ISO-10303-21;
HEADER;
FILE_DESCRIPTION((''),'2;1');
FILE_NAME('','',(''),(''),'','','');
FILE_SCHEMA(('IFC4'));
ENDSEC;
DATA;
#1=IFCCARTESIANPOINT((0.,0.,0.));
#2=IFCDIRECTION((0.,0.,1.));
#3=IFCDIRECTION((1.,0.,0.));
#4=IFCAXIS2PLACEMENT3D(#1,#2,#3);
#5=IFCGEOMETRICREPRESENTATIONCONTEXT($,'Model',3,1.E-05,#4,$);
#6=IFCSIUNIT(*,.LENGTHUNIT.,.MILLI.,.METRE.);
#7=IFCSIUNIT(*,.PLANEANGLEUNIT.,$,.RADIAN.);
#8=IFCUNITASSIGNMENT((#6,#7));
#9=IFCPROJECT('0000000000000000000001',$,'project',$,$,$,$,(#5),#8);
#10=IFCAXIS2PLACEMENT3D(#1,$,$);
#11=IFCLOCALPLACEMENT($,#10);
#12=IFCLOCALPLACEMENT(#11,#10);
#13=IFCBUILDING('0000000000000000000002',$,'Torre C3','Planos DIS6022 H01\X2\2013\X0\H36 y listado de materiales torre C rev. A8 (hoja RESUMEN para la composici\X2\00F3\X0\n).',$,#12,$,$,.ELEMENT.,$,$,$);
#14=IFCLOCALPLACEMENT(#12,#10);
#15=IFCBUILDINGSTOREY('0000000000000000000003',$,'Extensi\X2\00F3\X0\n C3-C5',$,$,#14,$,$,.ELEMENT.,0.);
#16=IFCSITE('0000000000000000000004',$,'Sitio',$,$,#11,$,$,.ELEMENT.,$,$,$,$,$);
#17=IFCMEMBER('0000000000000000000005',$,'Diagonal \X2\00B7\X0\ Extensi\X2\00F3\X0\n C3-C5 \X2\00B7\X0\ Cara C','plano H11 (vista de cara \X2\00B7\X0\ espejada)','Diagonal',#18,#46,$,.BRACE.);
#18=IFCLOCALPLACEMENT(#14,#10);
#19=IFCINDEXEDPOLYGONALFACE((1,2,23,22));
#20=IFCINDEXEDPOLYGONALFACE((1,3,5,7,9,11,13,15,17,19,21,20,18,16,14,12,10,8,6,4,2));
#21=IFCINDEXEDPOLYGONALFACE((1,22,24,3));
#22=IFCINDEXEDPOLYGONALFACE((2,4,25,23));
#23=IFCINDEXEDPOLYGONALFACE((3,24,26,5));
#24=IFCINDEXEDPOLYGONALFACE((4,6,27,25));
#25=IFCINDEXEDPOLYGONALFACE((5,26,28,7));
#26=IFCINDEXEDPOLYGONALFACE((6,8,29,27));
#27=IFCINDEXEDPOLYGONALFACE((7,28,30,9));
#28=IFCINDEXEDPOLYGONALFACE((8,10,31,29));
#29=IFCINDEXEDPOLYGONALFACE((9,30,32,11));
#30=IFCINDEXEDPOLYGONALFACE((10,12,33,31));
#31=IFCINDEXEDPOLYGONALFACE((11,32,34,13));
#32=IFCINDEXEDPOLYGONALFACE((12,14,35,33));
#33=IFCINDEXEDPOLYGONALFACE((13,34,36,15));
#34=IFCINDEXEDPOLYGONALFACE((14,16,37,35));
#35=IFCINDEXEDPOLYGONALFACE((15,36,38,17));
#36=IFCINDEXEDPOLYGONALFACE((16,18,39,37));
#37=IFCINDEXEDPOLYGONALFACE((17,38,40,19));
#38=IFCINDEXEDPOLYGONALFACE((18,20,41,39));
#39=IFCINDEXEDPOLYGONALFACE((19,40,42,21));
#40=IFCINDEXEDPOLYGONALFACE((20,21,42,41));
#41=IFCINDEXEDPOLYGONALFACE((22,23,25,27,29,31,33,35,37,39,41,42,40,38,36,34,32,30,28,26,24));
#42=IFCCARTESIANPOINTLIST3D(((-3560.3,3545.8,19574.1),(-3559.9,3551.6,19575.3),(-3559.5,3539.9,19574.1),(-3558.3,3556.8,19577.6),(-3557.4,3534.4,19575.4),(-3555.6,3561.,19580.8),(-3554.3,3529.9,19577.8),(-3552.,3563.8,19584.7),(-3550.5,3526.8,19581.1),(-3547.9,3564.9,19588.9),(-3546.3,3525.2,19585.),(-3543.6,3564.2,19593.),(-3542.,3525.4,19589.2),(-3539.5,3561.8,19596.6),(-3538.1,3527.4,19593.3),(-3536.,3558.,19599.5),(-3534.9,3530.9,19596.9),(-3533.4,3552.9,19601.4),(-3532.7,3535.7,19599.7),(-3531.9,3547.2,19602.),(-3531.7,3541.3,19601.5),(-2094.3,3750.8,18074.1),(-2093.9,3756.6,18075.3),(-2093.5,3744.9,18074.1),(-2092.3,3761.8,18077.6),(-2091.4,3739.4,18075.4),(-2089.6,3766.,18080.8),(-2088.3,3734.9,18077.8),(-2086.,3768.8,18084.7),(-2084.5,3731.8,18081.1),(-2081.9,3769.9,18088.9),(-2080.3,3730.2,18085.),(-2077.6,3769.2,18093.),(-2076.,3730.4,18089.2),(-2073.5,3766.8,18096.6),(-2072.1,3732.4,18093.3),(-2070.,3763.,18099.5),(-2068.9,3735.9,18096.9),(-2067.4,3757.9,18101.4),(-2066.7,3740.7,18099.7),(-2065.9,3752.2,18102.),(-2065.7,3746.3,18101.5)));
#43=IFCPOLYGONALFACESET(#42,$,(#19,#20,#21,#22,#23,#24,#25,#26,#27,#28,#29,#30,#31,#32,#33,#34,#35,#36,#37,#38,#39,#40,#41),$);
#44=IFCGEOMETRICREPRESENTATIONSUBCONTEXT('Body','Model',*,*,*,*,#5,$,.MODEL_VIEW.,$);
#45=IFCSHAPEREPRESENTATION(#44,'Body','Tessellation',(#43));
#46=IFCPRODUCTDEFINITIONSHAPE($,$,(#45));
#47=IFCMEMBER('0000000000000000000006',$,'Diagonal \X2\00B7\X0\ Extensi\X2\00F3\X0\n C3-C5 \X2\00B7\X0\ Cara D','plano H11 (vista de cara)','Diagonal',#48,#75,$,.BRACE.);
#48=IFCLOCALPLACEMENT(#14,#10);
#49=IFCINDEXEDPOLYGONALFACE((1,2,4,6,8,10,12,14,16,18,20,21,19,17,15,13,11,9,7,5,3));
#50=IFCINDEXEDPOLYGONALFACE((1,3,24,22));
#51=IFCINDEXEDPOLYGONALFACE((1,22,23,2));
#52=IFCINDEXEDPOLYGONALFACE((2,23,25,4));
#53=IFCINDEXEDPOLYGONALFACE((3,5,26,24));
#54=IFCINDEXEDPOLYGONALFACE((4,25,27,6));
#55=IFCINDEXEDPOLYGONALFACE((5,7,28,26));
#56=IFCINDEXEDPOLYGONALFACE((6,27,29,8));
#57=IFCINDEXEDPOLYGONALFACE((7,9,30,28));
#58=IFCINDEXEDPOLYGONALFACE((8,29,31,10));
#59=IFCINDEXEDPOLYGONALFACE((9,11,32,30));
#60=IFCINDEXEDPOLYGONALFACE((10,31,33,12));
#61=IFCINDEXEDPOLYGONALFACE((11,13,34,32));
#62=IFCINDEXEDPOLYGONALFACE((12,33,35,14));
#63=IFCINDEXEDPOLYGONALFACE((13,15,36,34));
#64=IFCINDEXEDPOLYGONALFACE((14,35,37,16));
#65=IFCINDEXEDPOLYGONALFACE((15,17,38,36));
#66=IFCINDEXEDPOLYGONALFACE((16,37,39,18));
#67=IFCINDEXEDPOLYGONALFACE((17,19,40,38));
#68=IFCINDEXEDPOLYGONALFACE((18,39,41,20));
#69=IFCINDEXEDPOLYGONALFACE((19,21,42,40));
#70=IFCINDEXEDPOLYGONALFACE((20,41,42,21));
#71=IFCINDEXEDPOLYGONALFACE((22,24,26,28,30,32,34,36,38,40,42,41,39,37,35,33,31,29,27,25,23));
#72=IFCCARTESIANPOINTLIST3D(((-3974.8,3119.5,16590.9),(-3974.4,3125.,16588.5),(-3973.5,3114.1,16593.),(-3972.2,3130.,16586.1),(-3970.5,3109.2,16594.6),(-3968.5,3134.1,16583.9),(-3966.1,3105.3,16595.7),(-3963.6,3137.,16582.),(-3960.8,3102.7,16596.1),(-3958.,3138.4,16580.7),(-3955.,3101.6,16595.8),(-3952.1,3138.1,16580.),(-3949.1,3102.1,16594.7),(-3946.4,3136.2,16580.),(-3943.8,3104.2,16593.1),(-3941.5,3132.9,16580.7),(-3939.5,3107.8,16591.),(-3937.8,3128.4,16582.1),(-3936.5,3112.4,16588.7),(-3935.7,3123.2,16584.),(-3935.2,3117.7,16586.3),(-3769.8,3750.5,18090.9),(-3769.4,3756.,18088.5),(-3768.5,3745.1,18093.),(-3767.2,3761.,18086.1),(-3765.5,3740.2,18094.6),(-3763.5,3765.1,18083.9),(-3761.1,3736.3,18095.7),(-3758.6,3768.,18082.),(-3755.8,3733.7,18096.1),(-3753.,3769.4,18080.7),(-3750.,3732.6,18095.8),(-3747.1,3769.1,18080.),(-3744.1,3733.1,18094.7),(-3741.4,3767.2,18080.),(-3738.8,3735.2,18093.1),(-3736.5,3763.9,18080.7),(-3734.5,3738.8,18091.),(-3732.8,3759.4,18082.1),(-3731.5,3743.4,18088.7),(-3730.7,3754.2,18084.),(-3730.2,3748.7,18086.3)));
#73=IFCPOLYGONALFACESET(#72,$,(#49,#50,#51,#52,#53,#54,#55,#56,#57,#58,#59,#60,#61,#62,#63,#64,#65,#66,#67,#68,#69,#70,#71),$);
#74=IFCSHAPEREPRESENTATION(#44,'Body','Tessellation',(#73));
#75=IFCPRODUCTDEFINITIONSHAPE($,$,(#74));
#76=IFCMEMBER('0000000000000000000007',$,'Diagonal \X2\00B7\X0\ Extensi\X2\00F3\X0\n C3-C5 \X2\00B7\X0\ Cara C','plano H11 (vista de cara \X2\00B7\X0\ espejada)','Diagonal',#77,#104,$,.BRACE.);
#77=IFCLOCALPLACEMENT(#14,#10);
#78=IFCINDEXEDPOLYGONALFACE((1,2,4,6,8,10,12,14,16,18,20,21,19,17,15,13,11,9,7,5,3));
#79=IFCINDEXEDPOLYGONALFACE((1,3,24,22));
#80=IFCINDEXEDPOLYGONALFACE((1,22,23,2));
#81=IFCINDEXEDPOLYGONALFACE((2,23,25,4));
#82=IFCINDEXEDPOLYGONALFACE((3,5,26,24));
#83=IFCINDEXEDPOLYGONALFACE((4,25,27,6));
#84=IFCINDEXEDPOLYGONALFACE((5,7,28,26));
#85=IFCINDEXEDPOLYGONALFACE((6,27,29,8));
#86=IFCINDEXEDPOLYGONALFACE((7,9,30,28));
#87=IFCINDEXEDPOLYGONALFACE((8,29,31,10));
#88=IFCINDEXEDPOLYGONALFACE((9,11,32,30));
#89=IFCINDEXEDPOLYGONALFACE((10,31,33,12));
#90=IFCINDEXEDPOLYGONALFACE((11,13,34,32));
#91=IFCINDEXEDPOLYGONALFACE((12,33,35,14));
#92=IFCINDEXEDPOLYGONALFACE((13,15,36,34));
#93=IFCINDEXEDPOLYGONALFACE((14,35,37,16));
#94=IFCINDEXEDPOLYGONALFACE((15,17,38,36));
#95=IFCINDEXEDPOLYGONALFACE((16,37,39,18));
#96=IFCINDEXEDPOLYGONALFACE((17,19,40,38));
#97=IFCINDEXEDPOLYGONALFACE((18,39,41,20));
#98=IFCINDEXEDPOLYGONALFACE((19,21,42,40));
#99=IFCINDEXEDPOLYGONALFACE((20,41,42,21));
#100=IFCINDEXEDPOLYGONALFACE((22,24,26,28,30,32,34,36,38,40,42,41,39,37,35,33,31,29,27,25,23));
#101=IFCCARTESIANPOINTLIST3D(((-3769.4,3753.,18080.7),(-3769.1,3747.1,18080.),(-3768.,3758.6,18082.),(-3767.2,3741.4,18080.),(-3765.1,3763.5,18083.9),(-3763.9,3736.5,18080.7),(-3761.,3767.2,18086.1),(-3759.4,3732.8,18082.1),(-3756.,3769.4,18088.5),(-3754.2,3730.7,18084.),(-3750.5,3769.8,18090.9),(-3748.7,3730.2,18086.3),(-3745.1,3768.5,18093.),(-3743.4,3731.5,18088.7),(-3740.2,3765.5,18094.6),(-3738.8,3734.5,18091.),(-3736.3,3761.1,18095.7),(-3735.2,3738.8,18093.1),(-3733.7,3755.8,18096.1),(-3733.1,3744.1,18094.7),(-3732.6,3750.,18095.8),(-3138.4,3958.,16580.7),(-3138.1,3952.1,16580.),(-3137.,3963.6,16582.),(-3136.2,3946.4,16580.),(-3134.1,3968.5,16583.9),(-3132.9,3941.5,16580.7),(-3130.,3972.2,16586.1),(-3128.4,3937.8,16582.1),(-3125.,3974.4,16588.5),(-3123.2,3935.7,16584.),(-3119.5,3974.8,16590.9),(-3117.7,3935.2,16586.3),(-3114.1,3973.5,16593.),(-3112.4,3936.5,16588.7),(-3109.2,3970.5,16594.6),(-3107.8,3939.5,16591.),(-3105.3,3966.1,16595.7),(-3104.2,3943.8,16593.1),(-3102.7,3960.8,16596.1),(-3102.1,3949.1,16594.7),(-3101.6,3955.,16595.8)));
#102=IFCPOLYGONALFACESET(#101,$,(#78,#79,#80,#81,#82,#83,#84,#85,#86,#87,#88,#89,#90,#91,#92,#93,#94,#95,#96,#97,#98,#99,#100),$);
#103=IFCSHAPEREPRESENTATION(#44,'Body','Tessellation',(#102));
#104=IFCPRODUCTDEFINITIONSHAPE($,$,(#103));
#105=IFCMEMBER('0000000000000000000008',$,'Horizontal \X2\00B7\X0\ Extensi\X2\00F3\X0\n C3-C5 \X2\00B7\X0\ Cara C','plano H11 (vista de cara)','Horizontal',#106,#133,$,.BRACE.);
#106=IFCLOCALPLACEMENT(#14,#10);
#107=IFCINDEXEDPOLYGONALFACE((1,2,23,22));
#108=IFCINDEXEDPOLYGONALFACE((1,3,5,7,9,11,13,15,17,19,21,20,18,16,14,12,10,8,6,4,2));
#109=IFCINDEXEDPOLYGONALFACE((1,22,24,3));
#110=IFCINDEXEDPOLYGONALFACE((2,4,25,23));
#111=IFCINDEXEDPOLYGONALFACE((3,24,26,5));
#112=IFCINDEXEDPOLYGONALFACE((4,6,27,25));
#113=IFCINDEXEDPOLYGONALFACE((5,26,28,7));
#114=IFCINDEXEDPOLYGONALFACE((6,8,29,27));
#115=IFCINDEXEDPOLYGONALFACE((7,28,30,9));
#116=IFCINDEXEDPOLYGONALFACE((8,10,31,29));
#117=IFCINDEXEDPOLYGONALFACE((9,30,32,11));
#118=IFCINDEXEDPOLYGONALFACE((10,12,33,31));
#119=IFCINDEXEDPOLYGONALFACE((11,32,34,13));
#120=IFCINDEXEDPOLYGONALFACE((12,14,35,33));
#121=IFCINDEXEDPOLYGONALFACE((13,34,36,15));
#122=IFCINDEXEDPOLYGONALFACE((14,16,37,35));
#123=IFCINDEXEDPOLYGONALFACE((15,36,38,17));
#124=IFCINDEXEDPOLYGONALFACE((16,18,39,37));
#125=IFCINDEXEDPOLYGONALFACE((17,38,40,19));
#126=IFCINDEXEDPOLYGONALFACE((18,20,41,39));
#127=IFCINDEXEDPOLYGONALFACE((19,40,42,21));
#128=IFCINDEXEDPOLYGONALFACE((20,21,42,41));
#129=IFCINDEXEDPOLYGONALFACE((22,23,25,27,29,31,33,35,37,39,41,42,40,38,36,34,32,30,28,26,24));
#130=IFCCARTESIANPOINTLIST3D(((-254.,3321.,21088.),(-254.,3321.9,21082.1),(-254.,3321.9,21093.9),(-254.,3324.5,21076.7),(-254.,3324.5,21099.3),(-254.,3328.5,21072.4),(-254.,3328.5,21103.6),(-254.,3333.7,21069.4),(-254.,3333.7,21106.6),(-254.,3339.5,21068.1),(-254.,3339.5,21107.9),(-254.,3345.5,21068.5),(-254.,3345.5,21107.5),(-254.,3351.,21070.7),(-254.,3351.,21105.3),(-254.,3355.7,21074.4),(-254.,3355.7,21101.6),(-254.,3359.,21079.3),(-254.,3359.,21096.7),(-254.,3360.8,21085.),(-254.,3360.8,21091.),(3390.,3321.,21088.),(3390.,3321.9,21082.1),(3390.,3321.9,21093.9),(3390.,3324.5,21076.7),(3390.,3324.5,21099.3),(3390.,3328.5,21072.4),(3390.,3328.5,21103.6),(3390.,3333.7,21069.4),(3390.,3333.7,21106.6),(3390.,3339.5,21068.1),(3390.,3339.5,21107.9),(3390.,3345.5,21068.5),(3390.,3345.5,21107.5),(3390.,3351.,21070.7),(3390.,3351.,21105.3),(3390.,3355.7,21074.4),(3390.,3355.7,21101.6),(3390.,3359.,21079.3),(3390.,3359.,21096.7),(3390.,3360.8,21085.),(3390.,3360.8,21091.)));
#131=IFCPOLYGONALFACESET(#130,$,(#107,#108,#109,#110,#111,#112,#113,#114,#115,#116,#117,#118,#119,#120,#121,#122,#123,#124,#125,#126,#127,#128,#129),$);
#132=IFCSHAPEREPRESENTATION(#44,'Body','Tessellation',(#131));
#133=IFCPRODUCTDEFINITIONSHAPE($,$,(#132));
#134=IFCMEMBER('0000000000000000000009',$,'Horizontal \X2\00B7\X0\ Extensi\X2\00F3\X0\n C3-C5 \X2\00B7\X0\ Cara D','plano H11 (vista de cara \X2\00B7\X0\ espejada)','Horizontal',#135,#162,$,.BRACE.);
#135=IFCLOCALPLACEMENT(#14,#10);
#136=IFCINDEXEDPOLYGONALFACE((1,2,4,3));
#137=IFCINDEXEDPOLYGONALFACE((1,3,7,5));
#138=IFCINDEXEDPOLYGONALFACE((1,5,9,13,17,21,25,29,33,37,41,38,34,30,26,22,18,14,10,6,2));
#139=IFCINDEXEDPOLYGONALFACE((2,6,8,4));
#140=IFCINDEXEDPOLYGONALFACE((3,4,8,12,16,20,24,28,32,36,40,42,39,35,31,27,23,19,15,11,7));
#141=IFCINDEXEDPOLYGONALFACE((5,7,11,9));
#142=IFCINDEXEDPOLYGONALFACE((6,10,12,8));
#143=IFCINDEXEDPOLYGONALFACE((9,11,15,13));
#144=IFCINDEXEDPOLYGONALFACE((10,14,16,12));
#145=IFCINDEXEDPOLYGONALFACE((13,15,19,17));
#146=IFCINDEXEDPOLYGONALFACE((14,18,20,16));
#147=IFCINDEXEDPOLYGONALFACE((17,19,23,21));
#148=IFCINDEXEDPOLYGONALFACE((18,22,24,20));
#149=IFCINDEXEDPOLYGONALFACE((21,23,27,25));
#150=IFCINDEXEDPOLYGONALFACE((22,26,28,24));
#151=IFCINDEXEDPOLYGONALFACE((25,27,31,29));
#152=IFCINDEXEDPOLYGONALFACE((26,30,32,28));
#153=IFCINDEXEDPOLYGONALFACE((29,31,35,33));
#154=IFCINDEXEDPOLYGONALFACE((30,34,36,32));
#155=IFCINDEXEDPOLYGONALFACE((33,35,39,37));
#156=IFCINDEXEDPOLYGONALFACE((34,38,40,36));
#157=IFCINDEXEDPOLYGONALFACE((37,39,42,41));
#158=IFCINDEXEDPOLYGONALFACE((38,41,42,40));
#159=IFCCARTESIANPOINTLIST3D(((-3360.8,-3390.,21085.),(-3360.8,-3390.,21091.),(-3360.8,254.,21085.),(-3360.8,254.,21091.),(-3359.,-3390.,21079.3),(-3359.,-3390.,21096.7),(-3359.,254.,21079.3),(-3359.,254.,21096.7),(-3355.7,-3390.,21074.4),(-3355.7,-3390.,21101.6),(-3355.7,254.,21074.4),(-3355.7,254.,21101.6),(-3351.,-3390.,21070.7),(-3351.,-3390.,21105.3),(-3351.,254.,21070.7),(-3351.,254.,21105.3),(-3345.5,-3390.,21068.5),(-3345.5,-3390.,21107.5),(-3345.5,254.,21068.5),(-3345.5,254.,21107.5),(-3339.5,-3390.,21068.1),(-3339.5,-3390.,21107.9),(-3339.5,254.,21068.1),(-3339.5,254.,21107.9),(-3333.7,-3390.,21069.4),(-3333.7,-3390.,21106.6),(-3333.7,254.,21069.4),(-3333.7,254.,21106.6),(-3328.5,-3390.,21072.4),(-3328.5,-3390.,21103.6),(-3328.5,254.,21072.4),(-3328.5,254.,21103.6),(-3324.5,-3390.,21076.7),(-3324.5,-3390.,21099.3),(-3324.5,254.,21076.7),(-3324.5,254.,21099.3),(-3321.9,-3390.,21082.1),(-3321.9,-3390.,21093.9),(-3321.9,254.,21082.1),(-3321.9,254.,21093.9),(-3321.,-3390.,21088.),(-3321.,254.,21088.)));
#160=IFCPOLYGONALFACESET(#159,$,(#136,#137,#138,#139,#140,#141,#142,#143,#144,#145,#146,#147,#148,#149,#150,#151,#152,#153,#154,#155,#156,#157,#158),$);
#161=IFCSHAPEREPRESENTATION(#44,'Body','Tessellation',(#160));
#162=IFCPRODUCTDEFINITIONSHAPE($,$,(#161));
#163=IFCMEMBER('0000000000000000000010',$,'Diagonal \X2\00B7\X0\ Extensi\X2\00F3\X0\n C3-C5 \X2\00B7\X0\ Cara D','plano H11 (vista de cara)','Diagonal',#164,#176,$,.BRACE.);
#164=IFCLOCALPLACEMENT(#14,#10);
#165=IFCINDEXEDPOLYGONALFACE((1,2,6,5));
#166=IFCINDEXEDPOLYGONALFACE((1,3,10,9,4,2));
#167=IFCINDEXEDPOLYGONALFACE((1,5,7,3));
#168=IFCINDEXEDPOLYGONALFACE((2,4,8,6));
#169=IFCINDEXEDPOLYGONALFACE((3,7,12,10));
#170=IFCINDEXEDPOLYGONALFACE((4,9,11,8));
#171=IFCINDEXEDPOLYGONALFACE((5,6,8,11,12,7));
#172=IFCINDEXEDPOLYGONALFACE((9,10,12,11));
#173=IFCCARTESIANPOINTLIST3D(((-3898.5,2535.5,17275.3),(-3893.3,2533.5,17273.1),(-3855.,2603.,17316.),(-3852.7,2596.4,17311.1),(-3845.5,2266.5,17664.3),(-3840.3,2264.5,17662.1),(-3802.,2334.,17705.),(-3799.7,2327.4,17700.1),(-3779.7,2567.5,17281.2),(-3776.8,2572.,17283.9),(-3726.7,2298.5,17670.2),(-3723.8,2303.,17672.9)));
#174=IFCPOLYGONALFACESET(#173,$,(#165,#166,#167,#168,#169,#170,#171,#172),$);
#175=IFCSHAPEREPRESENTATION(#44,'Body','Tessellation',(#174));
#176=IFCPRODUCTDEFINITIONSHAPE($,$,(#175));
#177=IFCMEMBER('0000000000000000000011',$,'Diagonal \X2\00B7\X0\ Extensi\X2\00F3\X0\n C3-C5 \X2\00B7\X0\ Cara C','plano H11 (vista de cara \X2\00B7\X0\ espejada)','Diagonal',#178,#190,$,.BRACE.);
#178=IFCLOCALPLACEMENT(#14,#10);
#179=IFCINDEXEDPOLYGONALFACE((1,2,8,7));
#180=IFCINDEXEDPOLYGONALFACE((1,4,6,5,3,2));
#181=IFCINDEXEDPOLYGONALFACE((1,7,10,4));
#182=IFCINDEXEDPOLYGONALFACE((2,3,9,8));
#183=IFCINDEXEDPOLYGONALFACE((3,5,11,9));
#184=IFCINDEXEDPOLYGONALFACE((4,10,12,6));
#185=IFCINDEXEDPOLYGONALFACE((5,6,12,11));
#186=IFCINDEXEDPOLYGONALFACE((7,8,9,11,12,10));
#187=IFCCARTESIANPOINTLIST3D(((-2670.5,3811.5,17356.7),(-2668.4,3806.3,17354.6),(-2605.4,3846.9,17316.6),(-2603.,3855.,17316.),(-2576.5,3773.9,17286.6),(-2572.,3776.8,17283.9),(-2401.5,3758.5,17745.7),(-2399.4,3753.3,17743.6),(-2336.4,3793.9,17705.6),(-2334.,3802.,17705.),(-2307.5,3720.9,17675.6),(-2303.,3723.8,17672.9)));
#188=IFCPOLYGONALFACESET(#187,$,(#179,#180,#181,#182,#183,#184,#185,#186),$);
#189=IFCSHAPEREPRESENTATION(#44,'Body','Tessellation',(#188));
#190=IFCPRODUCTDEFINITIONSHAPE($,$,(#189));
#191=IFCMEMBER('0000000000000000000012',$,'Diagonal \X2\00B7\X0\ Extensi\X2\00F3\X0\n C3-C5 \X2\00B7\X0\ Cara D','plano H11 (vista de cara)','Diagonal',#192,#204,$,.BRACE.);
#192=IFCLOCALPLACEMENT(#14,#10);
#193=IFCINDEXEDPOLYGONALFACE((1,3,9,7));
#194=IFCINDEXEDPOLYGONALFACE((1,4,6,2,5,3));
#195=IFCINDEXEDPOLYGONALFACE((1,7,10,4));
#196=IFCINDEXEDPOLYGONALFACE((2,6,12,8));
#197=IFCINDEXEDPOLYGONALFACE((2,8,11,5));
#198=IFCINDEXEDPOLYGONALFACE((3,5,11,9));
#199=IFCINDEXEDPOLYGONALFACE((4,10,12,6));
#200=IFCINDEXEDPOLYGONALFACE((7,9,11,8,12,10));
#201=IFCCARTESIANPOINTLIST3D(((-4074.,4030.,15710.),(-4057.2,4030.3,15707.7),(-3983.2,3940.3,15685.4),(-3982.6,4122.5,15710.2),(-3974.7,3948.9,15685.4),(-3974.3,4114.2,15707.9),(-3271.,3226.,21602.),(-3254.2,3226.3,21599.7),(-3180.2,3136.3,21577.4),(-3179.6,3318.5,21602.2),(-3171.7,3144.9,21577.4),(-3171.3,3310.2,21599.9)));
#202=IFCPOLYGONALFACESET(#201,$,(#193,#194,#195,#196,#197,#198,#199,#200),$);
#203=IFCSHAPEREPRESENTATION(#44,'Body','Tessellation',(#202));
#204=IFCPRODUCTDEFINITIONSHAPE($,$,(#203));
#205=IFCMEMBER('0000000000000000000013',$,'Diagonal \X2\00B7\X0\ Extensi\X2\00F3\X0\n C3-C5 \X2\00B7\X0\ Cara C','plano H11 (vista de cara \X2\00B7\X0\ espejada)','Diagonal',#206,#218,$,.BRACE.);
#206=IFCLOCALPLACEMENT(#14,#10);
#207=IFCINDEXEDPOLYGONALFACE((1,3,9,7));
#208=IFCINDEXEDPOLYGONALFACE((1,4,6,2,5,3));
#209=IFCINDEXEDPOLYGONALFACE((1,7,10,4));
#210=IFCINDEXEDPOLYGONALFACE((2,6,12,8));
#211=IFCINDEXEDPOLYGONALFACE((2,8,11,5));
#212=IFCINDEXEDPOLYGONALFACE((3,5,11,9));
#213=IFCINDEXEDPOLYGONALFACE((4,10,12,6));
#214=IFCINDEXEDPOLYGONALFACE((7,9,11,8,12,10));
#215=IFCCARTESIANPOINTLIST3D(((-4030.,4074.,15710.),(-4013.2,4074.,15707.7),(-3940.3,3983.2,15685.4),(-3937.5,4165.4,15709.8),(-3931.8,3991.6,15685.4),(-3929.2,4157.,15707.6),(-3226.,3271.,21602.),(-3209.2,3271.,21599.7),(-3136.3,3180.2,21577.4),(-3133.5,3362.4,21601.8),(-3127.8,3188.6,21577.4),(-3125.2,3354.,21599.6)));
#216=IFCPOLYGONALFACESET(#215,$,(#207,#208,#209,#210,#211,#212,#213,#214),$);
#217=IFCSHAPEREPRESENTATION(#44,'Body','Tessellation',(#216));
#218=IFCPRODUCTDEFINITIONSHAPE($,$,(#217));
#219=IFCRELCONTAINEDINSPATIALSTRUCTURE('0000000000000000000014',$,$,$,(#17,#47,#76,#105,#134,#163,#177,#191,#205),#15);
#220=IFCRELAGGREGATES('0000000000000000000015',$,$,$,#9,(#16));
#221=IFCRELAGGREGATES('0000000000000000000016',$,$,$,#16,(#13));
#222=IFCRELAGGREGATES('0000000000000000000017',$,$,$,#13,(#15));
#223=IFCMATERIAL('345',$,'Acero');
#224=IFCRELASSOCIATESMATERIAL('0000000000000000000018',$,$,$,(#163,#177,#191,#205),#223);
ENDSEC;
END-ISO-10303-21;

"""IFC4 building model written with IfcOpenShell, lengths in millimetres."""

from ifc_helpers import new_model, si_unit, frame, frame_2d, origin, origin_with_axes, place, context, subcontext, project, spatial, circle, l_section, extrude, material, element, save


model = new_model("IFC4")

# Units and contexts
model_context = context("Model", 3, precision=1e-05, world=origin_with_axes())
body_context = subcontext(model_context, "Body", "Model", "MODEL_VIEW")
ifc_project = project(units=[si_unit("LENGTHUNIT", "METRE", prefix="MILLI"), si_unit("PLANEANGLEUNIT", "RADIAN")], contexts=[model_context])

# Site, building, storey
site_placement = place(None, origin())
site = spatial("IfcSite", under=ifc_project, at=site_placement, Name="Sitio", CompositionType="ELEMENT")
building_placement = place(site_placement, origin())
building = spatial("IfcBuilding", under=site, at=building_placement, Name="Torre C3", Description="Planos DIS6022 H01–H36 y listado de materiales torre C rev. A8 (hoja RESUMEN para la composición).", CompositionType="ELEMENT")
storey_placement = place(building_placement, origin())
storey = spatial("IfcBuildingStorey", under=building, at=storey_placement, Name="Extensión C3-C5", CompositionType="ELEMENT", Elevation=0.0)

# Members
ifc_material_1 = material(Name="345", Category="Acero")
for number, where, z_axis, x_axis, name in (
    (1, (-3546.0, 3545.0, 19588.0), (0.69564, 0.097276, -0.711774), (0.39331, -0.880677, 0.264036), "Diagonal · Extensión C3-C5 · Cara C"),
):
    element("IfcMember", number, at=place(storey_placement, frame(where, z_axis=z_axis, x_axis=x_axis)), inside=storey, Name=name, Description="plano H11 (vista de cara · espejada)", ObjectType="Diagonal", PredefinedType="BRACE", context=body_context, shape_type="SweptSolid", body=[
        extrude(circle(Radius=20.0), None, (0.0, 0.0, 1.0), 2107.4),
    ])
for number, where, z_axis, x_axis, name, description in (
    (2, (-3750.0, 3751.0, 18088.0), (-0.124986, -0.384714, -0.914535), (0.777051, -0.61109, 0.150868), "Diagonal · Extensión C3-C5 · Cara D", "plano H11 (vista de cara)"),
    (3, (-3751.0, 3750.0, 18088.0), (0.384714, 0.124986, -0.914535), (0.61109, -0.777051, 0.150868), "Diagonal · Extensión C3-C5 · Cara C", "plano H11 (vista de cara · espejada)"),
):
    element("IfcMember", number, at=place(storey_placement, frame(where, z_axis=z_axis, x_axis=x_axis)), inside=storey, Name=name, Description=description, ObjectType="Diagonal", PredefinedType="BRACE", context=body_context, shape_type="SweptSolid", body=[
        extrude(circle(Radius=20.0), None, (0.0, 0.0, 1.0), 1640.2),
    ])
for number, where, z_axis, x_axis, name, description in (
    (4, (-254.0, 3341.0, 21088.0), (1.0, 0.0, 0.0), (0.0, -1.0, 0.0), "Horizontal · Extensión C3-C5 · Cara C", "plano H11 (vista de cara)"),
    (5, (-3341.0, 254.0, 21088.0), (0.0, -1.0, 0.0), (1.0, 0.0, 0.0), "Horizontal · Extensión C3-C5 · Cara D", "plano H11 (vista de cara · espejada)"),
):
    element("IfcMember", number, at=place(storey_placement, frame(where, z_axis=z_axis, x_axis=x_axis)), inside=storey, Name=name, Description=description, ObjectType="Horizontal", PredefinedType="BRACE", context=body_context, shape_type="SweptSolid", body=[
        extrude(circle(Radius=20.0), None, (0.0, 0.0, 1.0), 3644.0),
    ])
for number, where, z_axis, x_axis, name, description in (
    (6, (-3802.0, 2334.0, 17705.0), (-0.111365, 0.565232, -0.81738), (0.868367, -0.344616, -0.35662), "Diagonal · Extensión C3-C5 · Cara D", "plano H11 (vista de cara)"),
    (7, (-2334.0, 3802.0, 17705.0), (-0.565232, 0.111365, -0.81738), (0.344616, -0.868367, -0.35662), "Diagonal · Extensión C3-C5 · Cara C", "plano H11 (vista de cara · espejada)"),
):
    element("IfcMember", number, at=place(storey_placement, frame(where, z_axis=z_axis, x_axis=x_axis)), inside=storey, material=ifc_material_1, Name=name, Description=description, ObjectType="Diagonal", PredefinedType="BRACE", context=body_context, shape_type="SweptSolid", body=[
        extrude(l_section(Depth=90.0, Width=90.0, Thickness=6.0, at=frame_2d((45.0, 45.0))), None, (0.0, 0.0, 1.0), 475.9),
    ])
for number, where, z_axis, x_axis, name, description in (
    (8, (-4074.0, 4030.0, 15710.0), (0.133821, -0.133987, 0.981906), (0.698705, -0.689893, -0.189364), "Diagonal · Extensión C3-C5 · Cara D", "plano H11 (vista de cara)"),
    (9, (-4030.0, 4074.0, 15710.0), (0.133987, -0.133821, 0.981906), (0.689893, -0.698705, -0.189364), "Diagonal · Extensión C3-C5 · Cara C", "plano H11 (vista de cara · espejada)"),
):
    element("IfcMember", number, at=place(storey_placement, frame(where, z_axis=z_axis, x_axis=x_axis)), inside=storey, material=ifc_material_1, Name=name, Description=description, ObjectType="Diagonal", PredefinedType="BRACE", context=body_context, shape_type="SweptSolid", body=[
        extrude(l_section(Depth=130.0, Width=130.0, Thickness=12.0, at=frame_2d((65.0, 65.0))), None, (0.0, 0.0, 1.0), 6000.6),
    ])

save(model, "model.ifc")
